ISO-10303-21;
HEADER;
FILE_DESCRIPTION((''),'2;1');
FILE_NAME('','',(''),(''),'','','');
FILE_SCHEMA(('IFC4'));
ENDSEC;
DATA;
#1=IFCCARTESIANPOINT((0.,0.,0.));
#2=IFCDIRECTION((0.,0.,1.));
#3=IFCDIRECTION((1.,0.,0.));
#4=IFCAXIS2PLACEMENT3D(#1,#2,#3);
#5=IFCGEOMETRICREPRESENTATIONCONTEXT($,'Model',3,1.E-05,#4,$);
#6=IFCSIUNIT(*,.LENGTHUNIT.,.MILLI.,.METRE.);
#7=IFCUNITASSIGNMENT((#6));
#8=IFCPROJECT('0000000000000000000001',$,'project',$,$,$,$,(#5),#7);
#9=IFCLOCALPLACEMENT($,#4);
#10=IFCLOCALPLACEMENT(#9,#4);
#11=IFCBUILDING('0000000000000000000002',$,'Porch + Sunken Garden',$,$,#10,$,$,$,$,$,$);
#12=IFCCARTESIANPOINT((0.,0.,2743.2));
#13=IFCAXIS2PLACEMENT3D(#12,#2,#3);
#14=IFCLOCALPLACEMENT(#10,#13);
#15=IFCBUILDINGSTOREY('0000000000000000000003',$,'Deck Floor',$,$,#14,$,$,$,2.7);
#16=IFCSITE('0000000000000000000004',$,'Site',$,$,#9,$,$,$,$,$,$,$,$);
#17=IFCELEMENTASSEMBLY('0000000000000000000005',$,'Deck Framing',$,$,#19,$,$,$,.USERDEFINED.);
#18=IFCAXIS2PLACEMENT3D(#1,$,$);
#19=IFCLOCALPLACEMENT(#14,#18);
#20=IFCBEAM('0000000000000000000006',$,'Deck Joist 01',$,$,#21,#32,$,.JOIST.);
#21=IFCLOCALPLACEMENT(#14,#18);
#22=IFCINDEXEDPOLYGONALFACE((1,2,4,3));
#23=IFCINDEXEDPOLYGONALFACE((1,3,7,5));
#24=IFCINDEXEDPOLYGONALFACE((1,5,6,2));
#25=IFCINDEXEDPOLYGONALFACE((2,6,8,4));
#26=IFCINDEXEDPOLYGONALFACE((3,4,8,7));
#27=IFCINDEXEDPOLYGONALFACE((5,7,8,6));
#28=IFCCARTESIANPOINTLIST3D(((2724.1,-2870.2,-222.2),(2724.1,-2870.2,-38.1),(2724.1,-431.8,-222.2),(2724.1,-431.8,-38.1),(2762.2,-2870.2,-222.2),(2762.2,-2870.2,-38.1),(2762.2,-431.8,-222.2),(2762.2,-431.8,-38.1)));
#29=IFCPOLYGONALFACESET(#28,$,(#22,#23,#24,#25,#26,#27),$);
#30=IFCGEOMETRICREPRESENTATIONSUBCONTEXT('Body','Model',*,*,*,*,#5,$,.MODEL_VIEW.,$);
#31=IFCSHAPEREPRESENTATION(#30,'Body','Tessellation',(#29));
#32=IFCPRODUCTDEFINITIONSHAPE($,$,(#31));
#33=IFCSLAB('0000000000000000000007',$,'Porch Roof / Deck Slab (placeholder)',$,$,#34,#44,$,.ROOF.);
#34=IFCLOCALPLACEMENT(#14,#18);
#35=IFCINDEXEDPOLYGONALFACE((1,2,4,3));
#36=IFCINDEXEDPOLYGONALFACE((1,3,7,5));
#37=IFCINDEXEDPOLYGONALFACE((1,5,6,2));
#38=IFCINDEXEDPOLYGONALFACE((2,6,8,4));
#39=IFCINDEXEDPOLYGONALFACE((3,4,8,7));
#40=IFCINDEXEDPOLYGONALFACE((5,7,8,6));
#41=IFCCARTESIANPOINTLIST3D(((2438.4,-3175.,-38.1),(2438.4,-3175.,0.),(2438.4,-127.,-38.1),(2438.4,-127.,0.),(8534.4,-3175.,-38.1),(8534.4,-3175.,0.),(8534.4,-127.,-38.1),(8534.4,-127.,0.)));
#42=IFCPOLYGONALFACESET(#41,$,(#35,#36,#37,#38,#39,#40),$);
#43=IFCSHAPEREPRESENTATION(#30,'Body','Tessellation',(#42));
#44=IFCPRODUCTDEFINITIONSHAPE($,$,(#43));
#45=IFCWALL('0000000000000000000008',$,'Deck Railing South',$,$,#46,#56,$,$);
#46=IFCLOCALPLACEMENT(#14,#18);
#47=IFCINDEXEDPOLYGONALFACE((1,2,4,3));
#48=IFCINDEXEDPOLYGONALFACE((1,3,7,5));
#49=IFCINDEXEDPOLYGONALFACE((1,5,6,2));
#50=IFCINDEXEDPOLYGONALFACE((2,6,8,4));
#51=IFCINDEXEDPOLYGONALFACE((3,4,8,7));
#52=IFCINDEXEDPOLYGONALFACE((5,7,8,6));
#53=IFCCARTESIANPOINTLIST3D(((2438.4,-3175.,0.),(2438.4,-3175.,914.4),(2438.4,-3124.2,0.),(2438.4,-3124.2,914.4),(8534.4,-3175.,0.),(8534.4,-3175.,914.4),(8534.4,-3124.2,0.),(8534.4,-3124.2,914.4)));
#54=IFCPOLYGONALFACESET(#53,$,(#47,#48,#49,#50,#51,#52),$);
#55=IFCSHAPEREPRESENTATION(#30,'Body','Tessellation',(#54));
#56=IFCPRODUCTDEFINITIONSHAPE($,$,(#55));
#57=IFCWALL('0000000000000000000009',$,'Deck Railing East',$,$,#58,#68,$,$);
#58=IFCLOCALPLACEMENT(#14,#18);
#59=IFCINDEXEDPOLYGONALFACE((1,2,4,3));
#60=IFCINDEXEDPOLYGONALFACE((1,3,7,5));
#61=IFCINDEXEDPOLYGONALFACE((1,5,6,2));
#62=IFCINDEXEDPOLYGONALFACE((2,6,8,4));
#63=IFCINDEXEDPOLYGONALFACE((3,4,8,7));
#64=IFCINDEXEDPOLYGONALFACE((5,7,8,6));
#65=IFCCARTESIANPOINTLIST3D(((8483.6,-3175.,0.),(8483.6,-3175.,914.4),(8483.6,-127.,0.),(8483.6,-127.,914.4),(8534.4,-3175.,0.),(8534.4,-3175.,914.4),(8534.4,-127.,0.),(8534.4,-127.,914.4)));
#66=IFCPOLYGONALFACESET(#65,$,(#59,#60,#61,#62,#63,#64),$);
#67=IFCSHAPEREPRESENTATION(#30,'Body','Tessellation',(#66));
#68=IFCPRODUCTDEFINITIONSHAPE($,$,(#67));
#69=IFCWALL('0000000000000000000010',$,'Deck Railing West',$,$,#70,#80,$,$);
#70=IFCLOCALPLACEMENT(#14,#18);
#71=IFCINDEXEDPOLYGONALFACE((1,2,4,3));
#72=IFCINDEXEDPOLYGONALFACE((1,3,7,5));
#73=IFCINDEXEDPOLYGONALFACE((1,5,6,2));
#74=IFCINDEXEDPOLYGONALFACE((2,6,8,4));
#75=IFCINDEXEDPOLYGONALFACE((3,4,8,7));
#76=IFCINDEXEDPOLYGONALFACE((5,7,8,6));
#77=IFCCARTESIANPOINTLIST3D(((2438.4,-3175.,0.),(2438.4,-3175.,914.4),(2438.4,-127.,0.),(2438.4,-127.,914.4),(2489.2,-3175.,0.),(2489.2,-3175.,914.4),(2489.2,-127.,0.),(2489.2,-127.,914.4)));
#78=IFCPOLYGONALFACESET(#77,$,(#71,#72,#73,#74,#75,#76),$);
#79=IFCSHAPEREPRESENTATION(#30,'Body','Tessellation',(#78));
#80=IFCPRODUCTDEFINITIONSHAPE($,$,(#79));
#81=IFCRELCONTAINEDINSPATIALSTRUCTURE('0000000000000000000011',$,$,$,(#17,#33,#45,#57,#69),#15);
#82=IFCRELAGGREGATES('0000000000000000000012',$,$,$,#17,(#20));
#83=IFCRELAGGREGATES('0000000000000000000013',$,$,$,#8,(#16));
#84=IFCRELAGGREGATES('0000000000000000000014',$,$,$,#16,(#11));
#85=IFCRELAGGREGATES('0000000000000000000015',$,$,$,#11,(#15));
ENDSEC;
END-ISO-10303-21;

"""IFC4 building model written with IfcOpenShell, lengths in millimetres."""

from ifc_helpers import new_model, si_unit, frame, origin_with_axes, origin_2d, place, context, subcontext, project, spatial, indexed_curve, rectangle, outline, extrude, element, aggregate, save


model = new_model("IFC4")

# Units and contexts
model_context = context("Model", 3, precision=1e-05, world=origin_with_axes())
body_context = subcontext(model_context, "Body", "Model", "MODEL_VIEW")
ifc_project = project(units=[si_unit("LENGTHUNIT", "METRE", prefix="MILLI")], contexts=[model_context])

# Site, building, storey
site_placement = place(None, origin_with_axes())
site = spatial("IfcSite", under=ifc_project, at=site_placement, Name="Site")
building_placement = place(site_placement, origin_with_axes())
building = spatial("IfcBuilding", under=site, at=building_placement, Name="Porch + Sunken Garden")
storey_placement = place(building_placement, frame((0.0, 0.0, 2743.2), z_axis=(0.0, 0.0, 1.0), x_axis=(1.0, 0.0, 0.0)))
storey = spatial("IfcBuildingStorey", under=building, at=storey_placement, Name="Deck Floor", Elevation=2.7)

# Element assembly, beam
assembly_placement = place(storey_placement, frame((0.0, 0.0, -2743.2), z_axis=(0.0, 0.0, 1.0), x_axis=(1.0, 0.0, 0.0)))
assembly = element("IfcElementAssembly", 1, at=assembly_placement, inside=storey, Name="Deck Framing", PredefinedType="USERDEFINED")
beam_1_placement = place(assembly_placement, frame((2743.2, -431.8, 2613.0), z_axis=(0.0, -1.0, 0.0), x_axis=(1.0, 0.0, 0.0)))
beam_1 = element("IfcBeam", 2, at=beam_1_placement, Name="Deck Joist 01", PredefinedType="JOIST", context=body_context, shape_type="SweptSolid", body=[
    extrude(rectangle(XDim=38.1, YDim=184.2, at=origin_2d()), origin_with_axes(), (0.0, 0.0, 1.0), 2438.4),
])
aggregate(assembly, [beam_1])

# Slab
slab_placement = place(storey_placement, frame((2438.4, -3175.0, -38.1), z_axis=(0.0, 0.0, 1.0), x_axis=(1.0, 0.0, 0.0)))
element("IfcSlab", 3, at=slab_placement, inside=storey, Name="Porch Roof / Deck Slab (placeholder)", PredefinedType="ROOF", context=body_context, shape_type="SweptSolid", body=[
    extrude(outline(indexed_curve([(0.0, 0.0), (6096.0, 0.0), (6096.0, 3048.0), (0.0, 3048.0), (0.0, 0.0)])), origin_with_axes(), (0.0, 0.0, 1.0), 38.1),
])

# Walls
wall_placement = place(storey_placement, frame((2438.4, -3175.0, 0.0), z_axis=(0.0, 0.0, 1.0), x_axis=(1.0, 0.0, 0.0)))
element("IfcWall", 4, at=wall_placement, inside=storey, Name="Deck Railing South", context=body_context, shape_type="SweptSolid", body=[
    extrude(outline(indexed_curve([(0.0, 0.0), (0.0, 50.8), (6096.0, 50.8), (6096.0, 0.0), (0.0, 0.0)], self_intersect=False)), origin_with_axes(), (0.0, 0.0, 1.0), 914.4),
])
for number, where, z_axis, x_axis, name in (
    (5, (8534.4, -3175.0, 0.0), (0.0, 0.0, 1.0), (0.0, 1.0, 0.0), "Deck Railing East"),
    (6, (2438.4, -127.0, 0.0), (0.0, 0.0, 1.0), (0.0, -1.0, 0.0), "Deck Railing West"),
):
    element("IfcWall", number, at=place(storey_placement, frame(where, z_axis=z_axis, x_axis=x_axis)), inside=storey, Name=name, context=body_context, shape_type="SweptSolid", body=[
        extrude(outline(indexed_curve([(0.0, 0.0), (0.0, 50.8), (3048.0, 50.8), (3048.0, 0.0), (0.0, 0.0)], self_intersect=False)), origin_with_axes(), (0.0, 0.0, 1.0), 914.4),
    ])

save(model, "model.ifc")
